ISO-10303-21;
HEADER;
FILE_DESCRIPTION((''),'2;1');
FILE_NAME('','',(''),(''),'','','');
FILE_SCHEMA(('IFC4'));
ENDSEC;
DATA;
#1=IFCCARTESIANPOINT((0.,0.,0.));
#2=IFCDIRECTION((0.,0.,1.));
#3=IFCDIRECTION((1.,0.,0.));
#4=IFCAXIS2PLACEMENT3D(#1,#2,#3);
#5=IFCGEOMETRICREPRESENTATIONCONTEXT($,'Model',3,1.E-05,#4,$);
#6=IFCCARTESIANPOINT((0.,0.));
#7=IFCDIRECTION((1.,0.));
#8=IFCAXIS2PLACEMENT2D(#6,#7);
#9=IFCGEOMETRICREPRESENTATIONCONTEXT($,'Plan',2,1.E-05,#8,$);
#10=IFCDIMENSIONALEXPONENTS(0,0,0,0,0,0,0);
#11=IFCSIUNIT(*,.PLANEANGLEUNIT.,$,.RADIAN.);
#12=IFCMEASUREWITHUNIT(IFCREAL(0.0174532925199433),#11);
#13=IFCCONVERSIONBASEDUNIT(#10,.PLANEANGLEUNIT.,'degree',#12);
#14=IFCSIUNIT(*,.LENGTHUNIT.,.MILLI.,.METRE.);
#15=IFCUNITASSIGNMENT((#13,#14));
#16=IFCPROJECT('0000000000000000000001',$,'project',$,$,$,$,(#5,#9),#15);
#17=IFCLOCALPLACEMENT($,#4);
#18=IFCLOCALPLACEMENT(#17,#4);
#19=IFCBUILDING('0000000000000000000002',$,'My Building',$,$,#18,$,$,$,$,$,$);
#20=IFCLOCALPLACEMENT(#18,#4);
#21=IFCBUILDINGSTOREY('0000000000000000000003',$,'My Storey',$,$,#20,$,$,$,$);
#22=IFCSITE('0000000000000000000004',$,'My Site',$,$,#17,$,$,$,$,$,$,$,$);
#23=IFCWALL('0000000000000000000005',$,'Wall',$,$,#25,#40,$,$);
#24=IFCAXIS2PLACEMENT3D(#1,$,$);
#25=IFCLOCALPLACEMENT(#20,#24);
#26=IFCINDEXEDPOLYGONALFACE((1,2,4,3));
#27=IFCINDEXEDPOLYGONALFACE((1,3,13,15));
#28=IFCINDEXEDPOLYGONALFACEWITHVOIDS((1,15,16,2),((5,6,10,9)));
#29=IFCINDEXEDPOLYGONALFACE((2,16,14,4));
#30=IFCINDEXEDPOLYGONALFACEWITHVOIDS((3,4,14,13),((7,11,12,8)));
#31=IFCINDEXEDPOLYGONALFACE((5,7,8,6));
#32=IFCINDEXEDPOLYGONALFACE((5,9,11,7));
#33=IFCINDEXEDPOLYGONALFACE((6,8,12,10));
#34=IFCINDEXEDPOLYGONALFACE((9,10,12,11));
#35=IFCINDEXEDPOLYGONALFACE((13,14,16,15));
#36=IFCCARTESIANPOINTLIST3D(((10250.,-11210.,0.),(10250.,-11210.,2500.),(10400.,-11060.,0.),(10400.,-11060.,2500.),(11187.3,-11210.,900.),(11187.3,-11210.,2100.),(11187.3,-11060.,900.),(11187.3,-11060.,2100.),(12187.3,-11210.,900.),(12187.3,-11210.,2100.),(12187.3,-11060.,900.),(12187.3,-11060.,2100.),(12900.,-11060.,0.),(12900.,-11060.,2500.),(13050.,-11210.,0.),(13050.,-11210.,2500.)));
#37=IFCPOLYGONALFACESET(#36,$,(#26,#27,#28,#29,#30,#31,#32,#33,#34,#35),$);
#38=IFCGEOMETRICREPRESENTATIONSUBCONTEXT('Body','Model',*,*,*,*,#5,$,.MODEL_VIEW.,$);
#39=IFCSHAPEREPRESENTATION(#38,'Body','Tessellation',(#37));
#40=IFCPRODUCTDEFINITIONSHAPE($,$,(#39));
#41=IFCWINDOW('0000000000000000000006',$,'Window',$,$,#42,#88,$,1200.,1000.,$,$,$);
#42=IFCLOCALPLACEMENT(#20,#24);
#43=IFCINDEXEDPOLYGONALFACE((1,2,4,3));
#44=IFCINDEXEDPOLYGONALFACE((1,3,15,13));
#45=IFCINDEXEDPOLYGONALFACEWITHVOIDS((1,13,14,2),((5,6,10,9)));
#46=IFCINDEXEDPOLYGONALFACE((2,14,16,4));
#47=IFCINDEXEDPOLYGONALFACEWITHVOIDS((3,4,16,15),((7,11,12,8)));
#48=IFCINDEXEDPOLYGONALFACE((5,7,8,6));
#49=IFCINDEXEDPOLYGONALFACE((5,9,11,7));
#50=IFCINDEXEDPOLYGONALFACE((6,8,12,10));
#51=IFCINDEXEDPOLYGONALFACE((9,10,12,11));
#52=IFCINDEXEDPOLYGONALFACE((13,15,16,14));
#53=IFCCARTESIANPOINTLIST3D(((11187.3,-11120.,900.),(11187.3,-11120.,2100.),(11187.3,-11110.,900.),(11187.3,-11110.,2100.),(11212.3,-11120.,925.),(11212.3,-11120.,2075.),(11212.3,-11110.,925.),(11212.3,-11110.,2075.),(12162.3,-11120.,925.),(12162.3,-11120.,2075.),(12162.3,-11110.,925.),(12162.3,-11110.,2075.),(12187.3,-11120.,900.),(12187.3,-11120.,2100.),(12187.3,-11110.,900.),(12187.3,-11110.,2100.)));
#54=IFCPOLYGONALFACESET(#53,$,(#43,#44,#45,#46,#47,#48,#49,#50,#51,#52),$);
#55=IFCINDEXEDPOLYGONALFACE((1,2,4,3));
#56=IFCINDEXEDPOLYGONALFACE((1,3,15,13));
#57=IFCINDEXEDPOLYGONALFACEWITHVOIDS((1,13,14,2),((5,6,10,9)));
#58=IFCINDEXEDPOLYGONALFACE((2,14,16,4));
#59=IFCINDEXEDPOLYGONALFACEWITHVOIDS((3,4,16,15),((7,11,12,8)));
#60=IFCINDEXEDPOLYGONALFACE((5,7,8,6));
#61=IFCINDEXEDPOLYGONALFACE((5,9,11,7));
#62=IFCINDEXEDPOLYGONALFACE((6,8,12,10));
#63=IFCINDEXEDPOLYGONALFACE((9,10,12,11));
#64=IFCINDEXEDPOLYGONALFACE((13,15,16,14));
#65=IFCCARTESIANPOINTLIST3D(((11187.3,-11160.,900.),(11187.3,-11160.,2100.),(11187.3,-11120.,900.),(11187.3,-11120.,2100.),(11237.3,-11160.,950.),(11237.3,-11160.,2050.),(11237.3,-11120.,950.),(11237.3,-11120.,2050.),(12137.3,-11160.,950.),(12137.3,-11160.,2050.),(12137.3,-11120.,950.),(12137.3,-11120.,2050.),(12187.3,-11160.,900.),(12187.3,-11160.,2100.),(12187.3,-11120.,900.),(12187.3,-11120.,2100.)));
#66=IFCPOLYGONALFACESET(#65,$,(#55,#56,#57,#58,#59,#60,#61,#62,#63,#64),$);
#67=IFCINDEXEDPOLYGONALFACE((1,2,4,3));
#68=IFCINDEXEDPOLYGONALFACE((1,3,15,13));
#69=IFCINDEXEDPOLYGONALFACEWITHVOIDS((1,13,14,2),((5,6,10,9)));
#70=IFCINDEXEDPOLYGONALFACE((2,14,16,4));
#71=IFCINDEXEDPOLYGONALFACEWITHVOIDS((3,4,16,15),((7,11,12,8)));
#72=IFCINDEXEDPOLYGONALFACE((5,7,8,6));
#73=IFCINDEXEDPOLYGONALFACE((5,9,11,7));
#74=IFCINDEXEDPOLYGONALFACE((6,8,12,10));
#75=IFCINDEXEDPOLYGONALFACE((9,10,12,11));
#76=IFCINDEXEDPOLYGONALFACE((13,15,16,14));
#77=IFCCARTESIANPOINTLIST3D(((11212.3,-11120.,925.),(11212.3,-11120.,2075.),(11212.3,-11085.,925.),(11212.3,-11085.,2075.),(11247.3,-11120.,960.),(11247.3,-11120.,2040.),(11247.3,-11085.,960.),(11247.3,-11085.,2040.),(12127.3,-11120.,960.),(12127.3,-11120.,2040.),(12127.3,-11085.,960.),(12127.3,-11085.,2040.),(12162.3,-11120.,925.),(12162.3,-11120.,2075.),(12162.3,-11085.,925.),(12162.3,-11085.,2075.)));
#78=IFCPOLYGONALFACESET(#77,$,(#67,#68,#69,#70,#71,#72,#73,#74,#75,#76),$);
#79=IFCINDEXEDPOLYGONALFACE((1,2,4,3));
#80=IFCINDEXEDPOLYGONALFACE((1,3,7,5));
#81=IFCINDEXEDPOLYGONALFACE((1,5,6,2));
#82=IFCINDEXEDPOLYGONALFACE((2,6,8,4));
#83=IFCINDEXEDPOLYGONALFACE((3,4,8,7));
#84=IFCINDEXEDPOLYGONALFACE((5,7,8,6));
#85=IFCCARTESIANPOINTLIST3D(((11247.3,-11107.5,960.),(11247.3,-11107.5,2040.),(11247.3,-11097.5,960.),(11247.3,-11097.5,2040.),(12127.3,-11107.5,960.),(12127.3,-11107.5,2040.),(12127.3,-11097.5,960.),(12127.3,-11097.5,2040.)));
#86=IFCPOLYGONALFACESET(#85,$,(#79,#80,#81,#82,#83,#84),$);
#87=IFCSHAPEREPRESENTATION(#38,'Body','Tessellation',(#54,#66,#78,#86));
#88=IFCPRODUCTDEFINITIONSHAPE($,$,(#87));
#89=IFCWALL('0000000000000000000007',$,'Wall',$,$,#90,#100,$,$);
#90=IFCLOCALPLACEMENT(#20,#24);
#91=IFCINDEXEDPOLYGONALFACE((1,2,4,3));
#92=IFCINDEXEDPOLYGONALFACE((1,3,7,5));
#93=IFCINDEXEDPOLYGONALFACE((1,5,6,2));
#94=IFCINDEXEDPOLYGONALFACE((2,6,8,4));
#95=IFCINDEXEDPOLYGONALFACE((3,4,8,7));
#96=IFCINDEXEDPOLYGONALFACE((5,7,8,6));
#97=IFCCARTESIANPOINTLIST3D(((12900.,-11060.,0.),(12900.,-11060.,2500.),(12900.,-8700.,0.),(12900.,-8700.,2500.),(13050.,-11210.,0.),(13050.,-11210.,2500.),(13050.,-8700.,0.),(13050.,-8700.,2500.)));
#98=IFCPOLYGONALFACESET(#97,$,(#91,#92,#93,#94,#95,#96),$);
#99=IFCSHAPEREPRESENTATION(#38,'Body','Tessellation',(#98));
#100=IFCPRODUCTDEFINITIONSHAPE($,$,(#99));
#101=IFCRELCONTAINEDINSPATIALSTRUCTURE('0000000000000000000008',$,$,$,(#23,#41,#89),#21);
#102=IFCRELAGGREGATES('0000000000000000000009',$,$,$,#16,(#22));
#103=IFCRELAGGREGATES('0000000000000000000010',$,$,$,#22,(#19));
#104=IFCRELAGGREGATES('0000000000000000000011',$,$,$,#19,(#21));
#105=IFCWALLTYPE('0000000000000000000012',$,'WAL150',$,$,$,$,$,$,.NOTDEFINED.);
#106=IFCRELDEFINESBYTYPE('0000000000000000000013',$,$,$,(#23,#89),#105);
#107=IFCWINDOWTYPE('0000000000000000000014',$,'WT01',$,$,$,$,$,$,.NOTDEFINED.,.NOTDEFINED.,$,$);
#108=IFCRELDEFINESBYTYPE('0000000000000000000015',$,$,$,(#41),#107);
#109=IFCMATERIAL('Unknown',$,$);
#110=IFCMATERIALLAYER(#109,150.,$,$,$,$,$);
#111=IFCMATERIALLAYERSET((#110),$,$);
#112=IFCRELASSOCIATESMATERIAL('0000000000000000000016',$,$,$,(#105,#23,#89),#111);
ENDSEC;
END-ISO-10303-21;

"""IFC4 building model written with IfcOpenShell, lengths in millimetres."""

from ifc_helpers import new_model, entity, si_unit, converted_unit, frame, origin_with_axes, origin_2d_with_axis, place, context, subcontext, project, spatial, line, indexed_curve, outline, extrude, shape, source, transform, mapped, material, layer, layer_set, layer_usage, type_object, type_shapes, element, fill, save


model = new_model("IFC4")

# Units and contexts
model_context = context("Model", 3, precision=1e-05, world=origin_with_axes())
plan_context = context("Plan", 2, precision=1e-05, world=origin_2d_with_axis())
body_context_1 = subcontext(model_context, "Body", "Model", "MODEL_VIEW")
body_context_2 = subcontext(plan_context, "Body", "Plan", "PLAN_VIEW")
ifc_project = project(units=[converted_unit("PLANEANGLEUNIT", "degree", entity("IfcReal", 0.0174532925199433), si_unit("PLANEANGLEUNIT", "RADIAN"), dimensions=[0, 0, 0, 0, 0, 0, 0]), si_unit("LENGTHUNIT", "METRE", prefix="MILLI")], contexts=[model_context, plan_context])

# Site, building, storey
site_placement = place(None, origin_with_axes())
site = spatial("IfcSite", under=ifc_project, at=site_placement, Name="My Site")
building_placement = place(site_placement, origin_with_axes())
building = spatial("IfcBuilding", under=site, at=building_placement, Name="My Building")
storey_placement = place(building_placement, origin_with_axes())
storey = spatial("IfcBuildingStorey", under=building, at=storey_placement, Name="My Storey")

# Shared definitions
ifc_material = material(Name="Unknown")

# Shared definitions
ifc_layer_1 = layer(ifc_material, 150.0)
ifc_layer_set_1 = layer_set([ifc_layer_1])
wall_type_1 = type_object("IfcWallType", Name="WAL150", PredefinedType="NOTDEFINED", material=ifc_layer_set_1)

# Wall, opening, window
ifc_layer_usage_1 = layer_usage(ifc_layer_set_1, "AXIS2", "POSITIVE", 0.0)
wall_1_placement = place(storey_placement, frame((10250.0, -11210.0, 0.0), z_axis=(0.0, 0.0, 1.0), x_axis=(1.0, 0.0, 0.0)))
wall_1 = element("IfcWall", 1, at=wall_1_placement, inside=storey, type_object=wall_type_1, material=ifc_layer_usage_1, Name="Wall", context=body_context_1, shape_type="SweptSolid", body=[
    extrude(outline(indexed_curve([(0.0, 0.0), (150.0, 150.0), (2650.0, 150.0), (2800.0, 0.0)], segments=[line(1, 2, 3, 4, 1)])), origin_with_axes(), (0.0, 0.0, 1.0), 2500.0),
])
shared_shape_1 = source(origin_with_axes(), body_context_1, "Body", "SweptSolid", [
    extrude(outline(indexed_curve([(0.0, 0.0), (1000.0, 0.0), (1000.0, 1200.0), (0.0, 1200.0)], segments=[line(1, 2, 3, 4, 1)])), frame((0.0, -600.0, 0.0), z_axis=(0.0, -1.0, 0.0), x_axis=(1.0, 0.0, 0.0)), (0.0, 0.0, -1.0), 1200.0),
])
opening_1_placement = place(wall_1_placement, frame((937.3, 0.0, 900.0), z_axis=(0.0, 0.0, 1.0), x_axis=(1.0, 0.0, 0.0)))
opening_1 = element("IfcOpeningElement", 2, at=opening_1_placement, cuts=wall_1, PredefinedType="OPENING", context=body_context_1, shape_type="MappedRepresentation", body=[
    mapped(shared_shape_1, transform((0.0, 0.0, 0.0), x_axis=(1.0, 0.0, 0.0), y_axis=(0.0, 1.0, 0.0), z_axis=(0.0, 0.0, 1.0), scale=1.0)),
])
window_type = type_object("IfcWindowType", Name="WT01", PartitioningType="NOTDEFINED", PredefinedType="NOTDEFINED")
shared_shape_2 = source(origin_with_axes(), body_context_1, "Body", "SweptSolid", [
    extrude(outline(indexed_curve([(0.0, 0.0), (1000.0, 0.0), (1000.0, 1200.0), (0.0, 1200.0)], segments=[line(1, 2, 3, 4, 1)]), holes=[indexed_curve([(25.0, 25.0), (975.0, 25.0), (975.0, 1175.0), (25.0, 1175.0)], segments=[line(1, 2, 3, 4, 1)])]), frame((0.0, 90.0, 0.0), z_axis=(0.0, -1.0, 0.0), x_axis=(1.0, 0.0, 0.0)), (0.0, 0.0, -1.0), 10.0),
    extrude(outline(indexed_curve([(0.0, 0.0), (1000.0, 0.0), (1000.0, 1200.0), (0.0, 1200.0)], segments=[line(1, 2, 3, 4, 1)]), holes=[indexed_curve([(50.0, 50.0), (950.0, 50.0), (950.0, 1150.0), (50.0, 1150.0)], segments=[line(1, 2, 3, 4, 1)])]), frame((0.0, 50.0, 0.0), z_axis=(0.0, -1.0, 0.0), x_axis=(1.0, 0.0, 0.0)), (0.0, 0.0, -1.0), 40.0),
    extrude(outline(indexed_curve([(0.0, 0.0), (950.0, 0.0), (950.0, 1150.0), (0.0, 1150.0)], segments=[line(1, 2, 3, 4, 1)]), holes=[indexed_curve([(35.0, 35.0), (915.0, 35.0), (915.0, 1115.0), (35.0, 1115.0)], segments=[line(1, 2, 3, 4, 1)])]), frame((25.0, 90.0, 25.0), z_axis=(0.0, -1.0, 0.0), x_axis=(1.0, 0.0, 0.0)), (0.0, 0.0, -1.0), 35.0),
    extrude(outline(indexed_curve([(35.0, 35.0), (915.0, 35.0), (915.0, 1115.0), (35.0, 1115.0)], segments=[line(1, 2, 3, 4, 1)])), frame((25.0, 102.5, 25.0), z_axis=(0.0, -1.0, 0.0), x_axis=(1.0, 0.0, 0.0)), (0.0, 0.0, -1.0), 10.0),
])
shared_shape_3 = source(origin_with_axes(), body_context_2, "Body", "Curve2D", [
    entity("IfcIndexedPolyCurve", entity("IfcCartesianPointList2D", [[50.0, 50.0], [950.0, 50.0]])),
    entity("IfcIndexedPolyCurve", entity("IfcCartesianPointList2D", [[0.0, 100.0], [25.0, 100.0], [25.0, 90.0], [50.0, 90.0], [50.0, 50.0], [0.0, 50.0]]), [entity("IfcLineIndex", [1, 2, 3, 4, 5, 6, 1])]),
    entity("IfcIndexedPolyCurve", entity("IfcCartesianPointList2D", [[1000.0, 100.0], [975.0, 100.0], [975.0, 90.0], [950.0, 90.0], [950.0, 50.0], [1000.0, 50.0]]), [entity("IfcLineIndex", [1, 2, 3, 4, 5, 6, 1])]),
    entity("IfcIndexedPolyCurve", entity("IfcCartesianPointList2D", [[25.0, 90.0], [60.0, 90.0], [60.0, 125.0], [25.0, 125.0]]), [entity("IfcLineIndex", [1, 2, 3, 4, 1])]),
    entity("IfcIndexedPolyCurve", entity("IfcCartesianPointList2D", [[975.0, 90.0], [940.0, 90.0], [940.0, 125.0], [975.0, 125.0]]), [entity("IfcLineIndex", [1, 2, 3, 4, 1])]),
    entity("IfcIndexedPolyCurve", entity("IfcCartesianPointList2D", [[60.0, 90.0], [940.0, 90.0]])),
    entity("IfcIndexedPolyCurve", entity("IfcCartesianPointList2D", [[60.0, 125.0], [940.0, 125.0]])),
    entity("IfcIndexedPolyCurve", entity("IfcCartesianPointList2D", [[60.0, 107.5], [940.0, 107.5]])),
])
type_shapes(window_type, [shared_shape_2, shared_shape_3])
window_placement = place(opening_1_placement, origin_with_axes())
window = element("IfcWindow", 3, at=window_placement, inside=storey, type_object=window_type, Name="Window", OverallHeight=1200.0, OverallWidth=1000.0, shapes=[
    shape(body_context_1, "Body", "MappedRepresentation", [mapped(shared_shape_2, transform((0.0, 0.0, 0.0), x_axis=(1.0, 0.0, 0.0), y_axis=(0.0, 1.0, 0.0), z_axis=(0.0, 0.0, 1.0), scale=1.0))]),
    shape(body_context_2, "Body", "MappedRepresentation", [mapped(shared_shape_3, transform((0.0, 0.0, 0.0), x_axis=(1.0, 0.0, 0.0), y_axis=(0.0, 1.0, 0.0), z_axis=(0.0, 0.0, 1.0), scale=1.0))]),
])
fill(opening_1, window)

# Wall
ifc_layer_usage_2 = layer_usage(ifc_layer_set_1, "AXIS2", "POSITIVE", 0.0)
wall_2_placement = place(storey_placement, frame((13050.0, -11210.0, 0.0), z_axis=(0.0, 0.0, 1.0), x_axis=(0.0, 1.0, 0.0)))
element("IfcWall", 4, at=wall_2_placement, inside=storey, type_object=wall_type_1, material=ifc_layer_usage_2, Name="Wall", context=body_context_1, shape_type="SweptSolid", body=[
    extrude(outline(indexed_curve([(0.0, 0.0), (150.0, 150.0), (2510.0, 150.0), (2510.0, 0.0)], segments=[line(1, 2, 3, 4, 1)])), origin_with_axes(), (0.0, 0.0, 1.0), 2500.0),
])

save(model, "model.ifc")
